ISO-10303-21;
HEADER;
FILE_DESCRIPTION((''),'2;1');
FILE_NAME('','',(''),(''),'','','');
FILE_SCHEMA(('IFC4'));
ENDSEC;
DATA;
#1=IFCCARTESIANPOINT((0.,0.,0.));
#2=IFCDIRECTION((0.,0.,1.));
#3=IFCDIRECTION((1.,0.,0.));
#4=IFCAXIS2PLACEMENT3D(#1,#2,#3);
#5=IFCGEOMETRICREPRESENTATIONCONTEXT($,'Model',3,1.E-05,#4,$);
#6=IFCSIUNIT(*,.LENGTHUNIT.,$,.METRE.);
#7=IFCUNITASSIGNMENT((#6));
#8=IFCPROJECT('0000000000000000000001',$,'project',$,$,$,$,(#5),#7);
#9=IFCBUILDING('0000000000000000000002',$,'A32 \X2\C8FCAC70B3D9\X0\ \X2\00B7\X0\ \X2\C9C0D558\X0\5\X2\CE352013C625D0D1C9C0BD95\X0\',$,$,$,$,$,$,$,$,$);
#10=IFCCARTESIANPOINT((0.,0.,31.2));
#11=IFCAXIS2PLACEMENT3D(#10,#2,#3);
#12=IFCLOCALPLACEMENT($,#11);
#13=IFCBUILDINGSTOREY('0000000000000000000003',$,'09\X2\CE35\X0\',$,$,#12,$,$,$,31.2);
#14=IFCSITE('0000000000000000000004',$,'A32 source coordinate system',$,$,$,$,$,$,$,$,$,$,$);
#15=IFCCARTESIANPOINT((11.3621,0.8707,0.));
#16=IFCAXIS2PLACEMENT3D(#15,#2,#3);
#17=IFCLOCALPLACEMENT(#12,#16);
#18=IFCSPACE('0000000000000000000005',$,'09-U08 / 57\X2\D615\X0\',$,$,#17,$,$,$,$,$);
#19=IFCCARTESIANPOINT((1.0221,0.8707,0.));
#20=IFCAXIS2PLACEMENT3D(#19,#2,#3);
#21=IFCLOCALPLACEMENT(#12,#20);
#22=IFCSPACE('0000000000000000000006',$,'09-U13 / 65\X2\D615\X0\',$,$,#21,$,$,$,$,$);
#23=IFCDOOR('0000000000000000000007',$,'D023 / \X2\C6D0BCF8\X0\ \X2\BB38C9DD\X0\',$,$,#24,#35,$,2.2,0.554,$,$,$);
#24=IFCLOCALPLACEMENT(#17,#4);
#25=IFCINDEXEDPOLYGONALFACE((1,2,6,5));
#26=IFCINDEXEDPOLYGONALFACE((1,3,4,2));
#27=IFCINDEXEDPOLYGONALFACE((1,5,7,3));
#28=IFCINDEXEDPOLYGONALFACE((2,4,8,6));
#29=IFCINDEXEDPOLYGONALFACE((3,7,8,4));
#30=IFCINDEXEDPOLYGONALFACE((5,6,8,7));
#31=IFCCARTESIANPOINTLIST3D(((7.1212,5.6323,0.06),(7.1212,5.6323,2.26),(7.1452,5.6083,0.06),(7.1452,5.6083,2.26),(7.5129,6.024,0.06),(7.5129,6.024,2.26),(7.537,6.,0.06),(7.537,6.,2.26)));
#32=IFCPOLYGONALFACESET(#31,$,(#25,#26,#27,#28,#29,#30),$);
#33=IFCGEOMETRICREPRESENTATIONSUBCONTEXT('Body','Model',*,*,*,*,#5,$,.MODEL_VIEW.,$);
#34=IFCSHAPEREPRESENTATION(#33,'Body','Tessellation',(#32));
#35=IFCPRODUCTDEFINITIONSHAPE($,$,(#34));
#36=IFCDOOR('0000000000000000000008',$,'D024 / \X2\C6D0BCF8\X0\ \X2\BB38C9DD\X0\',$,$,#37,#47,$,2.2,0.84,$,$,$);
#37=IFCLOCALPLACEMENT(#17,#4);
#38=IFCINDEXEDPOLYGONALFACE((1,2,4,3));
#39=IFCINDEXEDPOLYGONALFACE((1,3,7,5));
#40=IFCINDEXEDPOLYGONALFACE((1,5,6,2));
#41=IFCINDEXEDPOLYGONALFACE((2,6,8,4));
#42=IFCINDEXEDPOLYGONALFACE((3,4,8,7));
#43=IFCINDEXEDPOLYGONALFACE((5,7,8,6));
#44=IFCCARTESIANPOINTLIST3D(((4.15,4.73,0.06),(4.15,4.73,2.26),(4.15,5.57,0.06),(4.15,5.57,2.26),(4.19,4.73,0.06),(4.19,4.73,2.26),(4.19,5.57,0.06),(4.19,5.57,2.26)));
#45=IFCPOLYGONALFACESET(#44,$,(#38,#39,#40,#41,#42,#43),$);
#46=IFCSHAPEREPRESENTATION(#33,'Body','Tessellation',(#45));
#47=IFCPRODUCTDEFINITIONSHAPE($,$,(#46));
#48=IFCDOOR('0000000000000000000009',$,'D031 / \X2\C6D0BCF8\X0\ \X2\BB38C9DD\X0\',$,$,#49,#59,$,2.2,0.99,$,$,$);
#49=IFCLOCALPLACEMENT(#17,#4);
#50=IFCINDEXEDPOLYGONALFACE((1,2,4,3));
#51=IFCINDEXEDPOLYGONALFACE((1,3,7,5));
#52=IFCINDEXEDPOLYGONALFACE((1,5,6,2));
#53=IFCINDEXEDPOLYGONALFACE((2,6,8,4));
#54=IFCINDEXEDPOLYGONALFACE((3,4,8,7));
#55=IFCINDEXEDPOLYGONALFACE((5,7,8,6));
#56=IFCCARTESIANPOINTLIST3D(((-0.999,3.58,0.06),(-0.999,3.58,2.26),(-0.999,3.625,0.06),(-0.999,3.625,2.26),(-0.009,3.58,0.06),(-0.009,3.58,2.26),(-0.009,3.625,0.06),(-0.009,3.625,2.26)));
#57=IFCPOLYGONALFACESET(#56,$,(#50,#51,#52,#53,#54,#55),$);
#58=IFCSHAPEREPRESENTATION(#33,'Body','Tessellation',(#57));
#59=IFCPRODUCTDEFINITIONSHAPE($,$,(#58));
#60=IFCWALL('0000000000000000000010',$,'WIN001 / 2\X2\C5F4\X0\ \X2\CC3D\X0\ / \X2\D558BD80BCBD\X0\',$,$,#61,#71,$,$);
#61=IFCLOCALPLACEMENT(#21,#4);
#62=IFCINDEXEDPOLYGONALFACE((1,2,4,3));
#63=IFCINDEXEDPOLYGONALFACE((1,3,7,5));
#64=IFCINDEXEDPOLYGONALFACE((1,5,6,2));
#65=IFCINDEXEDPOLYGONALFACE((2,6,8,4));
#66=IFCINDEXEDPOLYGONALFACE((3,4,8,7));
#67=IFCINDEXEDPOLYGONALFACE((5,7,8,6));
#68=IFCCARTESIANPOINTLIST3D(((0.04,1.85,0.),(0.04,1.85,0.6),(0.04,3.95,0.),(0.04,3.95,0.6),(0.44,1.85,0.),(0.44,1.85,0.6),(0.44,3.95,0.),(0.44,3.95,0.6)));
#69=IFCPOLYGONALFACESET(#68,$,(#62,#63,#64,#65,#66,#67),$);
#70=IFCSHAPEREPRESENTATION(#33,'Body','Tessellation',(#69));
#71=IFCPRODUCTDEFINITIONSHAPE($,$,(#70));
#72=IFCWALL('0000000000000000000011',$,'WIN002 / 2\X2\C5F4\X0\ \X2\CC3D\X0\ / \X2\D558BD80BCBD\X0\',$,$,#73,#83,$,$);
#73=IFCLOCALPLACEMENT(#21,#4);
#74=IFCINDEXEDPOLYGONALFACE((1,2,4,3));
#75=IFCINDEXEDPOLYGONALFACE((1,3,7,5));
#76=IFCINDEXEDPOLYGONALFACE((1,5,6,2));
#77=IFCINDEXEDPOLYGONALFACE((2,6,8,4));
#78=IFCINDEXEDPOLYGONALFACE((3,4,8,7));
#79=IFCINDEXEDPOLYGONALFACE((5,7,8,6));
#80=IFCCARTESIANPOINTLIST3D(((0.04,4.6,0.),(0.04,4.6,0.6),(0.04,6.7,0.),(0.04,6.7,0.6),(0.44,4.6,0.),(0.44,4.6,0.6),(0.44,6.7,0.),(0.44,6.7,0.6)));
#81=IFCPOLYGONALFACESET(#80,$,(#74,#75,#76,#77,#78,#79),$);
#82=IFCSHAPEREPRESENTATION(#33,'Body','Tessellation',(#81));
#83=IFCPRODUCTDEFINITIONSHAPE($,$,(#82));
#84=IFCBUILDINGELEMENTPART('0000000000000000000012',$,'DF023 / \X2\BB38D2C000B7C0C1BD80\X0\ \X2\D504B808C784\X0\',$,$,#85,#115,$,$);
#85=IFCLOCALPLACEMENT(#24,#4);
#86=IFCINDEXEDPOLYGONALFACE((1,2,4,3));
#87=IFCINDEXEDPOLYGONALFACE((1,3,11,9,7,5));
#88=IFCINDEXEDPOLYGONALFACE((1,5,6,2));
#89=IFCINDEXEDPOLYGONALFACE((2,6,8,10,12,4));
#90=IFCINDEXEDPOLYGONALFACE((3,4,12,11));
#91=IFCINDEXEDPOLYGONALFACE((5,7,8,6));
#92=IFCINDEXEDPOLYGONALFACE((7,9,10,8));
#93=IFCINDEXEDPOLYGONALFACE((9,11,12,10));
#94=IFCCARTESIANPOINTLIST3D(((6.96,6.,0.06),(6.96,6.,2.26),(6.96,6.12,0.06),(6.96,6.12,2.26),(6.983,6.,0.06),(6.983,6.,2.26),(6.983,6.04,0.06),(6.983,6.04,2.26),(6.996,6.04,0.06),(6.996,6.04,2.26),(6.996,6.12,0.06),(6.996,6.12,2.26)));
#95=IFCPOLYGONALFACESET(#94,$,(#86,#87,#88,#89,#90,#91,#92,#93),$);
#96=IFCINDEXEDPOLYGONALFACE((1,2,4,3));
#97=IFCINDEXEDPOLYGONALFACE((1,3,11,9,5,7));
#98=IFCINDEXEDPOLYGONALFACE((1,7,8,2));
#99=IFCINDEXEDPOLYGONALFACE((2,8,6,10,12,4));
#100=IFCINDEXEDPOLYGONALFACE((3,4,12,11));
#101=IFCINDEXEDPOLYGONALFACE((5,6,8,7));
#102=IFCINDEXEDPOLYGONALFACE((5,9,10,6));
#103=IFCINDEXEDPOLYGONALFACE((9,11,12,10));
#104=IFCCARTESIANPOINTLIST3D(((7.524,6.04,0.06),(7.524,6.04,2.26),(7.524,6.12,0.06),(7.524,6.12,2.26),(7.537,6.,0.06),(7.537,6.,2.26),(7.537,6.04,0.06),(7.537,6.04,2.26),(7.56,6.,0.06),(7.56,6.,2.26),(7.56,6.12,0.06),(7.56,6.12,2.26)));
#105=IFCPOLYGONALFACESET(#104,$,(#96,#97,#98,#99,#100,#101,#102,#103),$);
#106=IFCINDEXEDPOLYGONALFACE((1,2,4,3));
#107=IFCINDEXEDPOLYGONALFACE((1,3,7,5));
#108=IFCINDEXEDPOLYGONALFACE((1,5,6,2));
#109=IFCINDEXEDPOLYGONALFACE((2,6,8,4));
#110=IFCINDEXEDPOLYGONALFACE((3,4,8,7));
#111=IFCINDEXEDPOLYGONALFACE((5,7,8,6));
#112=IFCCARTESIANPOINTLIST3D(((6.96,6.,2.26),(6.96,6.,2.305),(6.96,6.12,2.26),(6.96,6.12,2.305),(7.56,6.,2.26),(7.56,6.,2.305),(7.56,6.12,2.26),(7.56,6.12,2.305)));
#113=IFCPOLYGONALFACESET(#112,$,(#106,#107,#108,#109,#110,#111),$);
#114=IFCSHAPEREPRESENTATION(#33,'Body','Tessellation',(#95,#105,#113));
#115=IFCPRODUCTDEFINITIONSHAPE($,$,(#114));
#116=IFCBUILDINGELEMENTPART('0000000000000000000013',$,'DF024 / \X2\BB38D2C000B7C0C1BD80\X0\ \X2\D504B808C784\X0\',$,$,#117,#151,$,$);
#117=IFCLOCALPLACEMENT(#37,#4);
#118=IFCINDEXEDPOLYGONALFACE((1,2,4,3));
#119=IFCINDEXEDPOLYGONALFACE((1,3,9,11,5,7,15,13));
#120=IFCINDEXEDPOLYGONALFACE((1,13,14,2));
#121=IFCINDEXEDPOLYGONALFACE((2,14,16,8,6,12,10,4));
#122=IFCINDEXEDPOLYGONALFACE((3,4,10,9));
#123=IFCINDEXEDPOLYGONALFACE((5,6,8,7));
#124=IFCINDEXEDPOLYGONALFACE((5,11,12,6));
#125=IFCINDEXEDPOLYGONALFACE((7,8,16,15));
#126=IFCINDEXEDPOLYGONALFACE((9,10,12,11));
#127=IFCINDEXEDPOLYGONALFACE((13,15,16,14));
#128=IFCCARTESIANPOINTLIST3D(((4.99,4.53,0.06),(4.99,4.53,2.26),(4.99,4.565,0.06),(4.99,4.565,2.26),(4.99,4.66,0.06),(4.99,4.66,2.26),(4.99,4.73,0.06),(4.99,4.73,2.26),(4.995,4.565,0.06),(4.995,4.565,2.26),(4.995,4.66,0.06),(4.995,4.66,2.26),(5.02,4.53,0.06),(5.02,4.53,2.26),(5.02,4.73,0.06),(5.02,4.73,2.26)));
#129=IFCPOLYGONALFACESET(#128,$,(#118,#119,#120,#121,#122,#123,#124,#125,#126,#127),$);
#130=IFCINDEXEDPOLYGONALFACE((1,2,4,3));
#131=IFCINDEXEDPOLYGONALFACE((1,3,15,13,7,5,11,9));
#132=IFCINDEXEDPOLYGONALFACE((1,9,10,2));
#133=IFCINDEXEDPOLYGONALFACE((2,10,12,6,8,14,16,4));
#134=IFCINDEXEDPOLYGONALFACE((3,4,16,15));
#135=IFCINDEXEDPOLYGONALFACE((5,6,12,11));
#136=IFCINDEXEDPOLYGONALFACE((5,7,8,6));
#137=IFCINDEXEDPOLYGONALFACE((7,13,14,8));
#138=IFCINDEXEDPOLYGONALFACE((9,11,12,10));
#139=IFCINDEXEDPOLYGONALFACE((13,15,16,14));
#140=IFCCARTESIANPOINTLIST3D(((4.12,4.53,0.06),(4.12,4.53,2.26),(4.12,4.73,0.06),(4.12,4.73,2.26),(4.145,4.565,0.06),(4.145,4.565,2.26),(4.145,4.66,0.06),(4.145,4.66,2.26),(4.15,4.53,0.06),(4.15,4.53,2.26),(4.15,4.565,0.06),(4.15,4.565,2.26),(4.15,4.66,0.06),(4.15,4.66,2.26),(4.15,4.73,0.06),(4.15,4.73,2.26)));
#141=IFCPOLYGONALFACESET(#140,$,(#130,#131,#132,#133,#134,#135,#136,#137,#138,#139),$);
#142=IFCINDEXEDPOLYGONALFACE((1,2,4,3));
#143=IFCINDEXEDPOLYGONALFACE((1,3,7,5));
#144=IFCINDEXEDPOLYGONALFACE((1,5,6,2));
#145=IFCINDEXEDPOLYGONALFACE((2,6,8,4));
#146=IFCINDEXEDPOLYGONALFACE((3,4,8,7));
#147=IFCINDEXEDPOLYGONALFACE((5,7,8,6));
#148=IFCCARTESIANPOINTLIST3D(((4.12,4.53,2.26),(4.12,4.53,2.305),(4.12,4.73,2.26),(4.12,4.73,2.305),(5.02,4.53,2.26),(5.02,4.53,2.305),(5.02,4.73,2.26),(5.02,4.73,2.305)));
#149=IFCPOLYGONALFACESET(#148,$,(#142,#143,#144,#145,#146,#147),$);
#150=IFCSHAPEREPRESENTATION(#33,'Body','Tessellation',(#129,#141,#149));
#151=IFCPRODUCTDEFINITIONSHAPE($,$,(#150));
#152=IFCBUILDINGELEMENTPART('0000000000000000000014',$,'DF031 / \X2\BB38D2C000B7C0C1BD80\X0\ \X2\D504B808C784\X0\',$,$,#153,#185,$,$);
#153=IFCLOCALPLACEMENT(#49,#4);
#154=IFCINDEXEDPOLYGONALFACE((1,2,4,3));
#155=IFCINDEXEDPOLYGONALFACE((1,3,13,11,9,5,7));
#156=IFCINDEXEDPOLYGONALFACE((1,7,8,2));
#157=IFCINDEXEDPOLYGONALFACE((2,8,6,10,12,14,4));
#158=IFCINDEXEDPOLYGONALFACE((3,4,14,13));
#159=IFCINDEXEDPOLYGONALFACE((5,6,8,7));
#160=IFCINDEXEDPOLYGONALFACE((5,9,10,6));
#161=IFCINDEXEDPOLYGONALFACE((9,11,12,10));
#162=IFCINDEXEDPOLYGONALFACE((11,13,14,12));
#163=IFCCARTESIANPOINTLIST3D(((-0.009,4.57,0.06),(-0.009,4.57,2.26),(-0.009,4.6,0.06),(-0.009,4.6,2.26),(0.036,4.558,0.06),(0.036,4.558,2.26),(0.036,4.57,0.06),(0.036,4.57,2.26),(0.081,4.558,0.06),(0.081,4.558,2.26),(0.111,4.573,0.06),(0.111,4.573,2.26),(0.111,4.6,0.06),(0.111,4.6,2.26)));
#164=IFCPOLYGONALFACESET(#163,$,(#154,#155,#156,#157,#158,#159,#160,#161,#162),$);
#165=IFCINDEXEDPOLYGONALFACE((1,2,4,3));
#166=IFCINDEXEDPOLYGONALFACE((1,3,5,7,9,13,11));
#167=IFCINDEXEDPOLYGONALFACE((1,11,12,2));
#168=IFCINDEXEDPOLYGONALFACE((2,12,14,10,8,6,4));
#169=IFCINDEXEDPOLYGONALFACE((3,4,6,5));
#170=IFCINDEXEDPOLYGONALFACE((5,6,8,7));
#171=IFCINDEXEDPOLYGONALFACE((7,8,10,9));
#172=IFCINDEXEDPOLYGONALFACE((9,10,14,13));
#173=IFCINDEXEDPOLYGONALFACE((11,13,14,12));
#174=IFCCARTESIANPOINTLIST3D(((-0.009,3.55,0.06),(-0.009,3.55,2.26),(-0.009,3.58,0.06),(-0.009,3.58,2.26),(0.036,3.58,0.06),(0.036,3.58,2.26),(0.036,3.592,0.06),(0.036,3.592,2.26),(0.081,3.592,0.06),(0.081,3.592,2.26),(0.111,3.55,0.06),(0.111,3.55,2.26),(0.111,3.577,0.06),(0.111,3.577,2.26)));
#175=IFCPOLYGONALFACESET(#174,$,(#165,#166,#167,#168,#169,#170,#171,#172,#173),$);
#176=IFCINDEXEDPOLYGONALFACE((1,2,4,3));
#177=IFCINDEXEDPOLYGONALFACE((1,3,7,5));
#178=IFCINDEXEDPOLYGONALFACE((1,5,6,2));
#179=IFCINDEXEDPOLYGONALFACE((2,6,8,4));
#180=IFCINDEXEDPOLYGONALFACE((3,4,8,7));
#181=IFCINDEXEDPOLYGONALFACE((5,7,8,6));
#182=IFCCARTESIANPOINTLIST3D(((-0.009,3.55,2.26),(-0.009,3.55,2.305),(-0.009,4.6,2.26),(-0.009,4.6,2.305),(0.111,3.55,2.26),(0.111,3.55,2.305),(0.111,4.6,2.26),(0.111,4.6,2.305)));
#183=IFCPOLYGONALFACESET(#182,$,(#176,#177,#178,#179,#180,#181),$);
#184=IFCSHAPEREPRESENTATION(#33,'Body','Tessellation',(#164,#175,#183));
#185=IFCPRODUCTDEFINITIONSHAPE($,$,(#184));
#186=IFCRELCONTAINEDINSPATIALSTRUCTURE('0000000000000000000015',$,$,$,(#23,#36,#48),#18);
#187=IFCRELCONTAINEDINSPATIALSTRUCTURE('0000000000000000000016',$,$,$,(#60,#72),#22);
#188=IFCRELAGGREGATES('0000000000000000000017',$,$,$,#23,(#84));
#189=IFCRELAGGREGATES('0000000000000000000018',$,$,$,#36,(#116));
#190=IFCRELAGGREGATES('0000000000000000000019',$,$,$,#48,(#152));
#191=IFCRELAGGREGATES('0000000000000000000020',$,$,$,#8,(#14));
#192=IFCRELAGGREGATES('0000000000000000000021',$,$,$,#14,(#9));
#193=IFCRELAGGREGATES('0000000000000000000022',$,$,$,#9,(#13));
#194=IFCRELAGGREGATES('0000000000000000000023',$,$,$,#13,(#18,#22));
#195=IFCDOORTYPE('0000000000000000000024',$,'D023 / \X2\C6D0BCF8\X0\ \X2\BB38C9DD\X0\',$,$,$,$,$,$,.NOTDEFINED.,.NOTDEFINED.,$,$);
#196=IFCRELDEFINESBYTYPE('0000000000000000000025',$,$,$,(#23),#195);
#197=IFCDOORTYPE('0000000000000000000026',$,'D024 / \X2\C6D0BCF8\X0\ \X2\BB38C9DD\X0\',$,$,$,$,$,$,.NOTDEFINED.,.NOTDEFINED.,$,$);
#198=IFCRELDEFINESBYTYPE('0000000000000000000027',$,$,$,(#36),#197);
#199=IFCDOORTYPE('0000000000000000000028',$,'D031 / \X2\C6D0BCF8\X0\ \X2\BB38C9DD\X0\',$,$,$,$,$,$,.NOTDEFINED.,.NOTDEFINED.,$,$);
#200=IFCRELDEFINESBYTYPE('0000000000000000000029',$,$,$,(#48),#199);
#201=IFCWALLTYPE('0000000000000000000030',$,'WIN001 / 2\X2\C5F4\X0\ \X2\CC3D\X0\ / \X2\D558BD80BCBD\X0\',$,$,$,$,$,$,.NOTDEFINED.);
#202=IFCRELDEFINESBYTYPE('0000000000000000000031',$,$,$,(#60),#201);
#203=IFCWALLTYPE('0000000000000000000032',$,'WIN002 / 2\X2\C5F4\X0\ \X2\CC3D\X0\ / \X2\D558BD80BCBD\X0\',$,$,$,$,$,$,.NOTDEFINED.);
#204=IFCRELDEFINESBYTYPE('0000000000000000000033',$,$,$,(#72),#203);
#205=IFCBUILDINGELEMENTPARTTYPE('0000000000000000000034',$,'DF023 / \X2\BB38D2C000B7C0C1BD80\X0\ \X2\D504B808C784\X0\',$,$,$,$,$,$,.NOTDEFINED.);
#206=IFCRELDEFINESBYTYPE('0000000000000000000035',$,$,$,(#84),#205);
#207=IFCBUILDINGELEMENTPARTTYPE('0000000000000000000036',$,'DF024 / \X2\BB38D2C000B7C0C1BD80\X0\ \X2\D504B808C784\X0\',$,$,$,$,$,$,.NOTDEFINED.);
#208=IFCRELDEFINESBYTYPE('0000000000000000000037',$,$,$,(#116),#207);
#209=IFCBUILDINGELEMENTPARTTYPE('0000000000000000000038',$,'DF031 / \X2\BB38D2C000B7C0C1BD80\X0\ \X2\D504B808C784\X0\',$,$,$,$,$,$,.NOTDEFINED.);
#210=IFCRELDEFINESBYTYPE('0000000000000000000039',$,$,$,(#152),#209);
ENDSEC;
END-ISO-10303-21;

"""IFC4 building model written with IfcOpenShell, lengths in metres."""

from ifc_helpers import new_model, si_unit, frame, origin, origin_with_axes, place, context, subcontext, project, spatial, polyline, outline, extrude, source, transform, mapped, type_object, type_shapes, element, aggregate, save


model = new_model("IFC4")

# Units and contexts
model_context = context("Model", 3, precision=1e-05, world=origin_with_axes())
body_context = subcontext(model_context, "Body", "Model", "MODEL_VIEW")
ifc_project = project(units=[si_unit("LENGTHUNIT", "METRE")], contexts=[model_context])

# Site, building, storey, space
site = spatial("IfcSite", under=ifc_project, Name="A32 source coordinate system")
building = spatial("IfcBuilding", under=site, Name="A32 주거동 · 지하5층–옥탑지붕")
storey_placement = place(None, frame((0.0, 0.0, 31.2), z_axis=(0.0, 0.0, 1.0), x_axis=(1.0, 0.0, 0.0)))
storey = spatial("IfcBuildingStorey", under=building, at=storey_placement, Name="09층", Elevation=31.2)
space_1_placement = place(storey_placement, frame((11.3621, 0.8707, 0.0), z_axis=(0.0, 0.0, 1.0), x_axis=(1.0, 0.0, 0.0)))
space_1 = spatial("IfcSpace", under=storey, at=space_1_placement, Name="09-U08 / 57형")

# Doors
door_type_1 = type_object("IfcDoorType", Name="D023 / 원본 문짝", OperationType="NOTDEFINED", PredefinedType="NOTDEFINED")
shared_shape_1 = source(origin(), body_context, "Body", "SweptSolid", [
    extrude(outline(polyline([(7.537, 6.0), (7.1452, 5.6083), (7.1212, 5.6323), (7.5129, 6.024), (7.537, 6.0)])), frame((0.0, 0.0, 0.06)), (0.0, 0.0, 1.0), 2.2),
])
type_shapes(door_type_1, [shared_shape_1])
door_1_placement = place(space_1_placement, origin_with_axes())
door_1 = element("IfcDoor", 1, at=door_1_placement, inside=space_1, type_object=door_type_1, Name="D023 / 원본 문짝", OverallHeight=2.2, OverallWidth=0.554, context=body_context, shape_type="MappedRepresentation", body=[
    mapped(shared_shape_1, transform((0.0, 0.0, 0.0), scale=1.0)),
])
door_type_2 = type_object("IfcDoorType", Name="D024 / 원본 문짝", OperationType="NOTDEFINED", PredefinedType="NOTDEFINED")
shared_shape_2 = source(origin(), body_context, "Body", "SweptSolid", [
    extrude(outline(polyline([(4.15, 4.73), (4.15, 5.57), (4.19, 5.57), (4.19, 4.73), (4.15, 4.73)])), frame((0.0, 0.0, 0.06)), (0.0, 0.0, 1.0), 2.2),
])
type_shapes(door_type_2, [shared_shape_2])
door_2_placement = place(space_1_placement, origin_with_axes())
door_2 = element("IfcDoor", 2, at=door_2_placement, inside=space_1, type_object=door_type_2, Name="D024 / 원본 문짝", OverallHeight=2.2, OverallWidth=0.84, context=body_context, shape_type="MappedRepresentation", body=[
    mapped(shared_shape_2, transform((0.0, 0.0, 0.0), scale=1.0)),
])
door_type_3 = type_object("IfcDoorType", Name="D031 / 원본 문짝", OperationType="NOTDEFINED", PredefinedType="NOTDEFINED")
shared_shape_3 = source(origin(), body_context, "Body", "SweptSolid", [
    extrude(outline(polyline([(-0.009, 3.58), (-0.999, 3.58), (-0.999, 3.625), (-0.009, 3.625), (-0.009, 3.58)])), frame((0.0, 0.0, 0.06)), (0.0, 0.0, 1.0), 2.2),
])
type_shapes(door_type_3, [shared_shape_3])
door_3_placement = place(space_1_placement, origin_with_axes())
door_3 = element("IfcDoor", 3, at=door_3_placement, inside=space_1, type_object=door_type_3, Name="D031 / 원본 문짝", OverallHeight=2.2, OverallWidth=0.99, context=body_context, shape_type="MappedRepresentation", body=[
    mapped(shared_shape_3, transform((0.0, 0.0, 0.0), scale=1.0)),
])

# Shared definitions
space_2_placement = place(storey_placement, frame((1.0221, 0.8707, 0.0), z_axis=(0.0, 0.0, 1.0), x_axis=(1.0, 0.0, 0.0)))
space_2 = spatial("IfcSpace", under=storey, at=space_2_placement, Name="09-U13 / 65형")

# Walls
wall_type_1 = type_object("IfcWallType", Name="WIN001 / 2열 창 / 하부벽", PredefinedType="NOTDEFINED")
shared_shape_4 = source(origin(), body_context, "Body", "SweptSolid", [
    extrude(outline(polyline([(0.04, 3.95), (0.44, 3.95), (0.44, 1.85), (0.04, 1.85), (0.04, 3.95)])), origin(), (0.0, 0.0, 1.0), 0.6),
])
type_shapes(wall_type_1, [shared_shape_4])
wall_1_placement = place(space_2_placement, origin_with_axes())
element("IfcWall", 4, at=wall_1_placement, inside=space_2, type_object=wall_type_1, Name="WIN001 / 2열 창 / 하부벽", context=body_context, shape_type="MappedRepresentation", body=[
    mapped(shared_shape_4, transform((0.0, 0.0, 0.0), scale=1.0)),
])
wall_type_2 = type_object("IfcWallType", Name="WIN002 / 2열 창 / 하부벽", PredefinedType="NOTDEFINED")
shared_shape_5 = source(origin(), body_context, "Body", "SweptSolid", [
    extrude(outline(polyline([(0.04, 6.7), (0.44, 6.7), (0.44, 4.6), (0.04, 4.6), (0.04, 6.7)])), origin(), (0.0, 0.0, 1.0), 0.6),
])
type_shapes(wall_type_2, [shared_shape_5])
wall_2_placement = place(space_2_placement, origin_with_axes())
element("IfcWall", 5, at=wall_2_placement, inside=space_2, type_object=wall_type_2, Name="WIN002 / 2열 창 / 하부벽", context=body_context, shape_type="MappedRepresentation", body=[
    mapped(shared_shape_5, transform((0.0, 0.0, 0.0), scale=1.0)),
])

# Building element parts
building_element_part_type_1 = type_object("IfcBuildingElementPartType", Name="DF023 / 문틀·상부 프레임", PredefinedType="NOTDEFINED")
shared_shape_6 = source(origin(), body_context, "Body", "SweptSolid", [
    extrude(outline(polyline([(6.996, 6.12), (6.996, 6.04), (6.983, 6.04), (6.983, 6.0), (6.96, 6.0), (6.96, 6.12), (6.996, 6.12)])), frame((0.0, 0.0, 0.06)), (0.0, 0.0, 1.0), 2.2),
    extrude(outline(polyline([(7.56, 6.0), (7.537, 6.0), (7.537, 6.04), (7.524, 6.04), (7.524, 6.12), (7.56, 6.12), (7.56, 6.0)])), frame((0.0, 0.0, 0.06)), (0.0, 0.0, 1.0), 2.2),
    extrude(outline(polyline([(6.96, 6.0), (6.96, 6.12), (7.56, 6.12), (7.56, 6.0), (6.96, 6.0)])), frame((0.0, 0.0, 2.26)), (0.0, 0.0, 1.0), 0.045),
])
type_shapes(building_element_part_type_1, [shared_shape_6])
building_element_part_1_placement = place(door_1_placement, origin_with_axes())
building_element_part_1 = element("IfcBuildingElementPart", 6, at=building_element_part_1_placement, type_object=building_element_part_type_1, Name="DF023 / 문틀·상부 프레임", context=body_context, shape_type="MappedRepresentation", body=[
    mapped(shared_shape_6, transform((0.0, 0.0, 0.0), scale=1.0)),
])
aggregate(door_1, [building_element_part_1])
building_element_part_type_2 = type_object("IfcBuildingElementPartType", Name="DF024 / 문틀·상부 프레임", PredefinedType="NOTDEFINED")
shared_shape_7 = source(origin(), body_context, "Body", "SweptSolid", [
    extrude(outline(polyline([(5.02, 4.53), (4.99, 4.53), (4.99, 4.565), (4.995, 4.565), (4.995, 4.66), (4.99, 4.66), (4.99, 4.73), (5.02, 4.73), (5.02, 4.53)])), frame((0.0, 0.0, 0.06)), (0.0, 0.0, 1.0), 2.2),
    extrude(outline(polyline([(4.15, 4.73), (4.15, 4.66), (4.145, 4.66), (4.145, 4.565), (4.15, 4.565), (4.15, 4.53), (4.12, 4.53), (4.12, 4.73), (4.15, 4.73)])), frame((0.0, 0.0, 0.06)), (0.0, 0.0, 1.0), 2.2),
    extrude(outline(polyline([(4.12, 4.53), (4.12, 4.73), (5.02, 4.73), (5.02, 4.53), (4.12, 4.53)])), frame((0.0, 0.0, 2.26)), (0.0, 0.0, 1.0), 0.045),
])
type_shapes(building_element_part_type_2, [shared_shape_7])
building_element_part_2_placement = place(door_2_placement, origin_with_axes())
building_element_part_2 = element("IfcBuildingElementPart", 7, at=building_element_part_2_placement, type_object=building_element_part_type_2, Name="DF024 / 문틀·상부 프레임", context=body_context, shape_type="MappedRepresentation", body=[
    mapped(shared_shape_7, transform((0.0, 0.0, 0.0), scale=1.0)),
])
aggregate(door_2, [building_element_part_2])
building_element_part_type_3 = type_object("IfcBuildingElementPartType", Name="DF031 / 문틀·상부 프레임", PredefinedType="NOTDEFINED")
shared_shape_8 = source(origin(), body_context, "Body", "SweptSolid", [
    extrude(outline(polyline([(0.111, 4.6), (0.111, 4.573), (0.081, 4.558), (0.036, 4.558), (0.036, 4.57), (-0.009, 4.57), (-0.009, 4.6), (0.111, 4.6)])), frame((0.0, 0.0, 0.06)), (0.0, 0.0, 1.0), 2.2),
    extrude(outline(polyline([(-0.009, 3.58), (0.036, 3.58), (0.036, 3.592), (0.081, 3.592), (0.111, 3.577), (0.111, 3.55), (-0.009, 3.55), (-0.009, 3.58)])), frame((0.0, 0.0, 0.06)), (0.0, 0.0, 1.0), 2.2),
    extrude(outline(polyline([(-0.009, 3.55), (-0.009, 4.6), (0.111, 4.6), (0.111, 3.55), (-0.009, 3.55)])), frame((0.0, 0.0, 2.26)), (0.0, 0.0, 1.0), 0.045),
])
type_shapes(building_element_part_type_3, [shared_shape_8])
building_element_part_3_placement = place(door_3_placement, origin_with_axes())
building_element_part_3 = element("IfcBuildingElementPart", 8, at=building_element_part_3_placement, type_object=building_element_part_type_3, Name="DF031 / 문틀·상부 프레임", context=body_context, shape_type="MappedRepresentation", body=[
    mapped(shared_shape_8, transform((0.0, 0.0, 0.0), scale=1.0)),
])
aggregate(door_3, [building_element_part_3])

save(model, "model.ifc")
